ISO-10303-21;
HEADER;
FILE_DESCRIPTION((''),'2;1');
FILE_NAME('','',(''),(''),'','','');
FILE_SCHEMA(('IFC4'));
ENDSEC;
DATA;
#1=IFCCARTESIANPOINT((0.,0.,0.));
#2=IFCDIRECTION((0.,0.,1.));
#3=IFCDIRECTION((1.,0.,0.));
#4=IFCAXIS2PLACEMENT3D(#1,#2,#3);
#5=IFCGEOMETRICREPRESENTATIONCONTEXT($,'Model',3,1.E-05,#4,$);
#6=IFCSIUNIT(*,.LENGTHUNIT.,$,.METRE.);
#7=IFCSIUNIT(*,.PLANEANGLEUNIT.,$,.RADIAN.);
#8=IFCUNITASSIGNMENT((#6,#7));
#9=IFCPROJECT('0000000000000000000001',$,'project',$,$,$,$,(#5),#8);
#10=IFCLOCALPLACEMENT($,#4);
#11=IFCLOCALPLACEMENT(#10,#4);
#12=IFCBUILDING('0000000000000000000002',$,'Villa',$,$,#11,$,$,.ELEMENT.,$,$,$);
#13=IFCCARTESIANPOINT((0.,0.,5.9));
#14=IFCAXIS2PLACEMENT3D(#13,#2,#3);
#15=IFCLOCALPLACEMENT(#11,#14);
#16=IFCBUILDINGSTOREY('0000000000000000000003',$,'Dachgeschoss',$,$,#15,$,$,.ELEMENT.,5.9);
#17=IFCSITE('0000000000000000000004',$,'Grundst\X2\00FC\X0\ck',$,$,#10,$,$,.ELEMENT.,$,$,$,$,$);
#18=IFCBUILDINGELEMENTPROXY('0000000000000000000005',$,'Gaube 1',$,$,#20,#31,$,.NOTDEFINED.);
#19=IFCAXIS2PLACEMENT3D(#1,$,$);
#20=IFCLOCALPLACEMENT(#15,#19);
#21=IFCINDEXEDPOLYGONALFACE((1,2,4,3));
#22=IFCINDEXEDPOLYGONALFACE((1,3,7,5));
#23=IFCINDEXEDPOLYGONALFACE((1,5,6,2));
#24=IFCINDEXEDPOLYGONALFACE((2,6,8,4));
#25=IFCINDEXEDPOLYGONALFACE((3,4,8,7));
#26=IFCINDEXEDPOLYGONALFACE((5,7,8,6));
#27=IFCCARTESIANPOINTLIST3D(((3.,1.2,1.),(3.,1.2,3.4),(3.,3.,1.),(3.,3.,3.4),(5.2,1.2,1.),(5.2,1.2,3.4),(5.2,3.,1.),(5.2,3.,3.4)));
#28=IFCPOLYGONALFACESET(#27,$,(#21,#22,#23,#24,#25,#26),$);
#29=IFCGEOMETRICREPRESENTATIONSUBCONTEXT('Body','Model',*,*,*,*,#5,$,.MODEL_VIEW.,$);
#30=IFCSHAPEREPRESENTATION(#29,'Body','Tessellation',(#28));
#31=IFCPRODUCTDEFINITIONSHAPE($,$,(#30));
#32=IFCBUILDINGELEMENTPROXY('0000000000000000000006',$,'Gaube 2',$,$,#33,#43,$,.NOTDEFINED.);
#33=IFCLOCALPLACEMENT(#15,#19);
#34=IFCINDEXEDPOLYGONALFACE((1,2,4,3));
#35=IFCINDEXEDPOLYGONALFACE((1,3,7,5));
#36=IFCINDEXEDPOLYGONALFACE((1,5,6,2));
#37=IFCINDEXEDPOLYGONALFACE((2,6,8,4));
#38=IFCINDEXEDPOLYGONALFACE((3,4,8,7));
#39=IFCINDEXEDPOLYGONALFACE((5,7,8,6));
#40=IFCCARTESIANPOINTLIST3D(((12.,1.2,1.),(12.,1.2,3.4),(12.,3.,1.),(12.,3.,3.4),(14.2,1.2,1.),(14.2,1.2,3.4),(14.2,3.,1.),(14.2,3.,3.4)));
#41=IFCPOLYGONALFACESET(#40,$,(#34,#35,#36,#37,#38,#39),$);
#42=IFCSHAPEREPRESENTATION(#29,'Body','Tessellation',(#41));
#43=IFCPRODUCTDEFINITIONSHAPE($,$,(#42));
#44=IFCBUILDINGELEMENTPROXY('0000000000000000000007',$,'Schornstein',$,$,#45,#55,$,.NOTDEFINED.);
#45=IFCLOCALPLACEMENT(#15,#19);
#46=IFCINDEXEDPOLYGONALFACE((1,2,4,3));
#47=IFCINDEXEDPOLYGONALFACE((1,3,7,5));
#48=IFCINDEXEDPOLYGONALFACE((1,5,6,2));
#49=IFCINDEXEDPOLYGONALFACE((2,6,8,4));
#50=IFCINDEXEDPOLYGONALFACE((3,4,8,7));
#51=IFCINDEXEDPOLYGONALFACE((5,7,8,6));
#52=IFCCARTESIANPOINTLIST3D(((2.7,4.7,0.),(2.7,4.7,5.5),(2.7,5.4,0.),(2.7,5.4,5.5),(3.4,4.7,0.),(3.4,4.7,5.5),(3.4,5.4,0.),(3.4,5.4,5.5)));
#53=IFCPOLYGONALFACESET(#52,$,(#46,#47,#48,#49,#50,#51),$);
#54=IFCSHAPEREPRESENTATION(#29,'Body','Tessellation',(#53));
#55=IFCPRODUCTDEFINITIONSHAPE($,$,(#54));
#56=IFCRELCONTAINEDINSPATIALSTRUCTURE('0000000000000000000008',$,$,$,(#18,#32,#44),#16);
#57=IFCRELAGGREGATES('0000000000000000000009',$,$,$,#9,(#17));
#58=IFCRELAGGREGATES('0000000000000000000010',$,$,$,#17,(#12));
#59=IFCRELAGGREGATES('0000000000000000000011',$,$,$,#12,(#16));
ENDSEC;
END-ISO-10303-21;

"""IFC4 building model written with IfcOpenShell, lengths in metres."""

from ifc_helpers import new_model, si_unit, frame, origin_with_axes, origin_2d, place, context, subcontext, project, spatial, rectangle, extrude, element, save


model = new_model("IFC4")

# Units and contexts
model_context = context("Model", 3, precision=1e-05, world=origin_with_axes())
body_context = subcontext(model_context, "Body", "Model", "MODEL_VIEW")
ifc_project = project(units=[si_unit("LENGTHUNIT", "METRE"), si_unit("PLANEANGLEUNIT", "RADIAN")], contexts=[model_context])

# Site, building, storey
site_placement = place(None, origin_with_axes())
site = spatial("IfcSite", under=ifc_project, at=site_placement, Name="Grundstück", CompositionType="ELEMENT")
building_placement = place(site_placement, origin_with_axes())
building = spatial("IfcBuilding", under=site, at=building_placement, Name="Villa", CompositionType="ELEMENT")
storey_placement = place(building_placement, frame((0.0, 0.0, 5.9), z_axis=(0.0, 0.0, 1.0), x_axis=(1.0, 0.0, 0.0)))
storey = spatial("IfcBuildingStorey", under=building, at=storey_placement, Name="Dachgeschoss", CompositionType="ELEMENT", Elevation=5.9)

# Building element proxies
for number, where, z_axis, x_axis, name in (
    (1, (4.1, 2.1, 1.0), (0.0, 0.0, 1.0), (1.0, 0.0, 0.0), "Gaube 1"),
    (2, (13.1, 2.1, 1.0), (0.0, 0.0, 1.0), (1.0, 0.0, 0.0), "Gaube 2"),
):
    element("IfcBuildingElementProxy", number, at=place(storey_placement, frame(where, z_axis=z_axis, x_axis=x_axis)), inside=storey, Name=name, PredefinedType="NOTDEFINED", context=body_context, shape_type="SweptSolid", body=[
        extrude(rectangle(XDim=2.2, YDim=1.8, at=origin_2d()), origin_with_axes(), (0.0, 0.0, 1.0), 2.4),
    ])
proxy_placement = place(storey_placement, frame((3.05, 5.05, 0.0), z_axis=(0.0, 0.0, 1.0), x_axis=(1.0, 0.0, 0.0)))
element("IfcBuildingElementProxy", 3, at=proxy_placement, inside=storey, Name="Schornstein", PredefinedType="NOTDEFINED", context=body_context, shape_type="SweptSolid", body=[
    extrude(rectangle(XDim=0.7, YDim=0.7, at=origin_2d()), origin_with_axes(), (0.0, 0.0, 1.0), 5.5),
])

save(model, "model.ifc")
